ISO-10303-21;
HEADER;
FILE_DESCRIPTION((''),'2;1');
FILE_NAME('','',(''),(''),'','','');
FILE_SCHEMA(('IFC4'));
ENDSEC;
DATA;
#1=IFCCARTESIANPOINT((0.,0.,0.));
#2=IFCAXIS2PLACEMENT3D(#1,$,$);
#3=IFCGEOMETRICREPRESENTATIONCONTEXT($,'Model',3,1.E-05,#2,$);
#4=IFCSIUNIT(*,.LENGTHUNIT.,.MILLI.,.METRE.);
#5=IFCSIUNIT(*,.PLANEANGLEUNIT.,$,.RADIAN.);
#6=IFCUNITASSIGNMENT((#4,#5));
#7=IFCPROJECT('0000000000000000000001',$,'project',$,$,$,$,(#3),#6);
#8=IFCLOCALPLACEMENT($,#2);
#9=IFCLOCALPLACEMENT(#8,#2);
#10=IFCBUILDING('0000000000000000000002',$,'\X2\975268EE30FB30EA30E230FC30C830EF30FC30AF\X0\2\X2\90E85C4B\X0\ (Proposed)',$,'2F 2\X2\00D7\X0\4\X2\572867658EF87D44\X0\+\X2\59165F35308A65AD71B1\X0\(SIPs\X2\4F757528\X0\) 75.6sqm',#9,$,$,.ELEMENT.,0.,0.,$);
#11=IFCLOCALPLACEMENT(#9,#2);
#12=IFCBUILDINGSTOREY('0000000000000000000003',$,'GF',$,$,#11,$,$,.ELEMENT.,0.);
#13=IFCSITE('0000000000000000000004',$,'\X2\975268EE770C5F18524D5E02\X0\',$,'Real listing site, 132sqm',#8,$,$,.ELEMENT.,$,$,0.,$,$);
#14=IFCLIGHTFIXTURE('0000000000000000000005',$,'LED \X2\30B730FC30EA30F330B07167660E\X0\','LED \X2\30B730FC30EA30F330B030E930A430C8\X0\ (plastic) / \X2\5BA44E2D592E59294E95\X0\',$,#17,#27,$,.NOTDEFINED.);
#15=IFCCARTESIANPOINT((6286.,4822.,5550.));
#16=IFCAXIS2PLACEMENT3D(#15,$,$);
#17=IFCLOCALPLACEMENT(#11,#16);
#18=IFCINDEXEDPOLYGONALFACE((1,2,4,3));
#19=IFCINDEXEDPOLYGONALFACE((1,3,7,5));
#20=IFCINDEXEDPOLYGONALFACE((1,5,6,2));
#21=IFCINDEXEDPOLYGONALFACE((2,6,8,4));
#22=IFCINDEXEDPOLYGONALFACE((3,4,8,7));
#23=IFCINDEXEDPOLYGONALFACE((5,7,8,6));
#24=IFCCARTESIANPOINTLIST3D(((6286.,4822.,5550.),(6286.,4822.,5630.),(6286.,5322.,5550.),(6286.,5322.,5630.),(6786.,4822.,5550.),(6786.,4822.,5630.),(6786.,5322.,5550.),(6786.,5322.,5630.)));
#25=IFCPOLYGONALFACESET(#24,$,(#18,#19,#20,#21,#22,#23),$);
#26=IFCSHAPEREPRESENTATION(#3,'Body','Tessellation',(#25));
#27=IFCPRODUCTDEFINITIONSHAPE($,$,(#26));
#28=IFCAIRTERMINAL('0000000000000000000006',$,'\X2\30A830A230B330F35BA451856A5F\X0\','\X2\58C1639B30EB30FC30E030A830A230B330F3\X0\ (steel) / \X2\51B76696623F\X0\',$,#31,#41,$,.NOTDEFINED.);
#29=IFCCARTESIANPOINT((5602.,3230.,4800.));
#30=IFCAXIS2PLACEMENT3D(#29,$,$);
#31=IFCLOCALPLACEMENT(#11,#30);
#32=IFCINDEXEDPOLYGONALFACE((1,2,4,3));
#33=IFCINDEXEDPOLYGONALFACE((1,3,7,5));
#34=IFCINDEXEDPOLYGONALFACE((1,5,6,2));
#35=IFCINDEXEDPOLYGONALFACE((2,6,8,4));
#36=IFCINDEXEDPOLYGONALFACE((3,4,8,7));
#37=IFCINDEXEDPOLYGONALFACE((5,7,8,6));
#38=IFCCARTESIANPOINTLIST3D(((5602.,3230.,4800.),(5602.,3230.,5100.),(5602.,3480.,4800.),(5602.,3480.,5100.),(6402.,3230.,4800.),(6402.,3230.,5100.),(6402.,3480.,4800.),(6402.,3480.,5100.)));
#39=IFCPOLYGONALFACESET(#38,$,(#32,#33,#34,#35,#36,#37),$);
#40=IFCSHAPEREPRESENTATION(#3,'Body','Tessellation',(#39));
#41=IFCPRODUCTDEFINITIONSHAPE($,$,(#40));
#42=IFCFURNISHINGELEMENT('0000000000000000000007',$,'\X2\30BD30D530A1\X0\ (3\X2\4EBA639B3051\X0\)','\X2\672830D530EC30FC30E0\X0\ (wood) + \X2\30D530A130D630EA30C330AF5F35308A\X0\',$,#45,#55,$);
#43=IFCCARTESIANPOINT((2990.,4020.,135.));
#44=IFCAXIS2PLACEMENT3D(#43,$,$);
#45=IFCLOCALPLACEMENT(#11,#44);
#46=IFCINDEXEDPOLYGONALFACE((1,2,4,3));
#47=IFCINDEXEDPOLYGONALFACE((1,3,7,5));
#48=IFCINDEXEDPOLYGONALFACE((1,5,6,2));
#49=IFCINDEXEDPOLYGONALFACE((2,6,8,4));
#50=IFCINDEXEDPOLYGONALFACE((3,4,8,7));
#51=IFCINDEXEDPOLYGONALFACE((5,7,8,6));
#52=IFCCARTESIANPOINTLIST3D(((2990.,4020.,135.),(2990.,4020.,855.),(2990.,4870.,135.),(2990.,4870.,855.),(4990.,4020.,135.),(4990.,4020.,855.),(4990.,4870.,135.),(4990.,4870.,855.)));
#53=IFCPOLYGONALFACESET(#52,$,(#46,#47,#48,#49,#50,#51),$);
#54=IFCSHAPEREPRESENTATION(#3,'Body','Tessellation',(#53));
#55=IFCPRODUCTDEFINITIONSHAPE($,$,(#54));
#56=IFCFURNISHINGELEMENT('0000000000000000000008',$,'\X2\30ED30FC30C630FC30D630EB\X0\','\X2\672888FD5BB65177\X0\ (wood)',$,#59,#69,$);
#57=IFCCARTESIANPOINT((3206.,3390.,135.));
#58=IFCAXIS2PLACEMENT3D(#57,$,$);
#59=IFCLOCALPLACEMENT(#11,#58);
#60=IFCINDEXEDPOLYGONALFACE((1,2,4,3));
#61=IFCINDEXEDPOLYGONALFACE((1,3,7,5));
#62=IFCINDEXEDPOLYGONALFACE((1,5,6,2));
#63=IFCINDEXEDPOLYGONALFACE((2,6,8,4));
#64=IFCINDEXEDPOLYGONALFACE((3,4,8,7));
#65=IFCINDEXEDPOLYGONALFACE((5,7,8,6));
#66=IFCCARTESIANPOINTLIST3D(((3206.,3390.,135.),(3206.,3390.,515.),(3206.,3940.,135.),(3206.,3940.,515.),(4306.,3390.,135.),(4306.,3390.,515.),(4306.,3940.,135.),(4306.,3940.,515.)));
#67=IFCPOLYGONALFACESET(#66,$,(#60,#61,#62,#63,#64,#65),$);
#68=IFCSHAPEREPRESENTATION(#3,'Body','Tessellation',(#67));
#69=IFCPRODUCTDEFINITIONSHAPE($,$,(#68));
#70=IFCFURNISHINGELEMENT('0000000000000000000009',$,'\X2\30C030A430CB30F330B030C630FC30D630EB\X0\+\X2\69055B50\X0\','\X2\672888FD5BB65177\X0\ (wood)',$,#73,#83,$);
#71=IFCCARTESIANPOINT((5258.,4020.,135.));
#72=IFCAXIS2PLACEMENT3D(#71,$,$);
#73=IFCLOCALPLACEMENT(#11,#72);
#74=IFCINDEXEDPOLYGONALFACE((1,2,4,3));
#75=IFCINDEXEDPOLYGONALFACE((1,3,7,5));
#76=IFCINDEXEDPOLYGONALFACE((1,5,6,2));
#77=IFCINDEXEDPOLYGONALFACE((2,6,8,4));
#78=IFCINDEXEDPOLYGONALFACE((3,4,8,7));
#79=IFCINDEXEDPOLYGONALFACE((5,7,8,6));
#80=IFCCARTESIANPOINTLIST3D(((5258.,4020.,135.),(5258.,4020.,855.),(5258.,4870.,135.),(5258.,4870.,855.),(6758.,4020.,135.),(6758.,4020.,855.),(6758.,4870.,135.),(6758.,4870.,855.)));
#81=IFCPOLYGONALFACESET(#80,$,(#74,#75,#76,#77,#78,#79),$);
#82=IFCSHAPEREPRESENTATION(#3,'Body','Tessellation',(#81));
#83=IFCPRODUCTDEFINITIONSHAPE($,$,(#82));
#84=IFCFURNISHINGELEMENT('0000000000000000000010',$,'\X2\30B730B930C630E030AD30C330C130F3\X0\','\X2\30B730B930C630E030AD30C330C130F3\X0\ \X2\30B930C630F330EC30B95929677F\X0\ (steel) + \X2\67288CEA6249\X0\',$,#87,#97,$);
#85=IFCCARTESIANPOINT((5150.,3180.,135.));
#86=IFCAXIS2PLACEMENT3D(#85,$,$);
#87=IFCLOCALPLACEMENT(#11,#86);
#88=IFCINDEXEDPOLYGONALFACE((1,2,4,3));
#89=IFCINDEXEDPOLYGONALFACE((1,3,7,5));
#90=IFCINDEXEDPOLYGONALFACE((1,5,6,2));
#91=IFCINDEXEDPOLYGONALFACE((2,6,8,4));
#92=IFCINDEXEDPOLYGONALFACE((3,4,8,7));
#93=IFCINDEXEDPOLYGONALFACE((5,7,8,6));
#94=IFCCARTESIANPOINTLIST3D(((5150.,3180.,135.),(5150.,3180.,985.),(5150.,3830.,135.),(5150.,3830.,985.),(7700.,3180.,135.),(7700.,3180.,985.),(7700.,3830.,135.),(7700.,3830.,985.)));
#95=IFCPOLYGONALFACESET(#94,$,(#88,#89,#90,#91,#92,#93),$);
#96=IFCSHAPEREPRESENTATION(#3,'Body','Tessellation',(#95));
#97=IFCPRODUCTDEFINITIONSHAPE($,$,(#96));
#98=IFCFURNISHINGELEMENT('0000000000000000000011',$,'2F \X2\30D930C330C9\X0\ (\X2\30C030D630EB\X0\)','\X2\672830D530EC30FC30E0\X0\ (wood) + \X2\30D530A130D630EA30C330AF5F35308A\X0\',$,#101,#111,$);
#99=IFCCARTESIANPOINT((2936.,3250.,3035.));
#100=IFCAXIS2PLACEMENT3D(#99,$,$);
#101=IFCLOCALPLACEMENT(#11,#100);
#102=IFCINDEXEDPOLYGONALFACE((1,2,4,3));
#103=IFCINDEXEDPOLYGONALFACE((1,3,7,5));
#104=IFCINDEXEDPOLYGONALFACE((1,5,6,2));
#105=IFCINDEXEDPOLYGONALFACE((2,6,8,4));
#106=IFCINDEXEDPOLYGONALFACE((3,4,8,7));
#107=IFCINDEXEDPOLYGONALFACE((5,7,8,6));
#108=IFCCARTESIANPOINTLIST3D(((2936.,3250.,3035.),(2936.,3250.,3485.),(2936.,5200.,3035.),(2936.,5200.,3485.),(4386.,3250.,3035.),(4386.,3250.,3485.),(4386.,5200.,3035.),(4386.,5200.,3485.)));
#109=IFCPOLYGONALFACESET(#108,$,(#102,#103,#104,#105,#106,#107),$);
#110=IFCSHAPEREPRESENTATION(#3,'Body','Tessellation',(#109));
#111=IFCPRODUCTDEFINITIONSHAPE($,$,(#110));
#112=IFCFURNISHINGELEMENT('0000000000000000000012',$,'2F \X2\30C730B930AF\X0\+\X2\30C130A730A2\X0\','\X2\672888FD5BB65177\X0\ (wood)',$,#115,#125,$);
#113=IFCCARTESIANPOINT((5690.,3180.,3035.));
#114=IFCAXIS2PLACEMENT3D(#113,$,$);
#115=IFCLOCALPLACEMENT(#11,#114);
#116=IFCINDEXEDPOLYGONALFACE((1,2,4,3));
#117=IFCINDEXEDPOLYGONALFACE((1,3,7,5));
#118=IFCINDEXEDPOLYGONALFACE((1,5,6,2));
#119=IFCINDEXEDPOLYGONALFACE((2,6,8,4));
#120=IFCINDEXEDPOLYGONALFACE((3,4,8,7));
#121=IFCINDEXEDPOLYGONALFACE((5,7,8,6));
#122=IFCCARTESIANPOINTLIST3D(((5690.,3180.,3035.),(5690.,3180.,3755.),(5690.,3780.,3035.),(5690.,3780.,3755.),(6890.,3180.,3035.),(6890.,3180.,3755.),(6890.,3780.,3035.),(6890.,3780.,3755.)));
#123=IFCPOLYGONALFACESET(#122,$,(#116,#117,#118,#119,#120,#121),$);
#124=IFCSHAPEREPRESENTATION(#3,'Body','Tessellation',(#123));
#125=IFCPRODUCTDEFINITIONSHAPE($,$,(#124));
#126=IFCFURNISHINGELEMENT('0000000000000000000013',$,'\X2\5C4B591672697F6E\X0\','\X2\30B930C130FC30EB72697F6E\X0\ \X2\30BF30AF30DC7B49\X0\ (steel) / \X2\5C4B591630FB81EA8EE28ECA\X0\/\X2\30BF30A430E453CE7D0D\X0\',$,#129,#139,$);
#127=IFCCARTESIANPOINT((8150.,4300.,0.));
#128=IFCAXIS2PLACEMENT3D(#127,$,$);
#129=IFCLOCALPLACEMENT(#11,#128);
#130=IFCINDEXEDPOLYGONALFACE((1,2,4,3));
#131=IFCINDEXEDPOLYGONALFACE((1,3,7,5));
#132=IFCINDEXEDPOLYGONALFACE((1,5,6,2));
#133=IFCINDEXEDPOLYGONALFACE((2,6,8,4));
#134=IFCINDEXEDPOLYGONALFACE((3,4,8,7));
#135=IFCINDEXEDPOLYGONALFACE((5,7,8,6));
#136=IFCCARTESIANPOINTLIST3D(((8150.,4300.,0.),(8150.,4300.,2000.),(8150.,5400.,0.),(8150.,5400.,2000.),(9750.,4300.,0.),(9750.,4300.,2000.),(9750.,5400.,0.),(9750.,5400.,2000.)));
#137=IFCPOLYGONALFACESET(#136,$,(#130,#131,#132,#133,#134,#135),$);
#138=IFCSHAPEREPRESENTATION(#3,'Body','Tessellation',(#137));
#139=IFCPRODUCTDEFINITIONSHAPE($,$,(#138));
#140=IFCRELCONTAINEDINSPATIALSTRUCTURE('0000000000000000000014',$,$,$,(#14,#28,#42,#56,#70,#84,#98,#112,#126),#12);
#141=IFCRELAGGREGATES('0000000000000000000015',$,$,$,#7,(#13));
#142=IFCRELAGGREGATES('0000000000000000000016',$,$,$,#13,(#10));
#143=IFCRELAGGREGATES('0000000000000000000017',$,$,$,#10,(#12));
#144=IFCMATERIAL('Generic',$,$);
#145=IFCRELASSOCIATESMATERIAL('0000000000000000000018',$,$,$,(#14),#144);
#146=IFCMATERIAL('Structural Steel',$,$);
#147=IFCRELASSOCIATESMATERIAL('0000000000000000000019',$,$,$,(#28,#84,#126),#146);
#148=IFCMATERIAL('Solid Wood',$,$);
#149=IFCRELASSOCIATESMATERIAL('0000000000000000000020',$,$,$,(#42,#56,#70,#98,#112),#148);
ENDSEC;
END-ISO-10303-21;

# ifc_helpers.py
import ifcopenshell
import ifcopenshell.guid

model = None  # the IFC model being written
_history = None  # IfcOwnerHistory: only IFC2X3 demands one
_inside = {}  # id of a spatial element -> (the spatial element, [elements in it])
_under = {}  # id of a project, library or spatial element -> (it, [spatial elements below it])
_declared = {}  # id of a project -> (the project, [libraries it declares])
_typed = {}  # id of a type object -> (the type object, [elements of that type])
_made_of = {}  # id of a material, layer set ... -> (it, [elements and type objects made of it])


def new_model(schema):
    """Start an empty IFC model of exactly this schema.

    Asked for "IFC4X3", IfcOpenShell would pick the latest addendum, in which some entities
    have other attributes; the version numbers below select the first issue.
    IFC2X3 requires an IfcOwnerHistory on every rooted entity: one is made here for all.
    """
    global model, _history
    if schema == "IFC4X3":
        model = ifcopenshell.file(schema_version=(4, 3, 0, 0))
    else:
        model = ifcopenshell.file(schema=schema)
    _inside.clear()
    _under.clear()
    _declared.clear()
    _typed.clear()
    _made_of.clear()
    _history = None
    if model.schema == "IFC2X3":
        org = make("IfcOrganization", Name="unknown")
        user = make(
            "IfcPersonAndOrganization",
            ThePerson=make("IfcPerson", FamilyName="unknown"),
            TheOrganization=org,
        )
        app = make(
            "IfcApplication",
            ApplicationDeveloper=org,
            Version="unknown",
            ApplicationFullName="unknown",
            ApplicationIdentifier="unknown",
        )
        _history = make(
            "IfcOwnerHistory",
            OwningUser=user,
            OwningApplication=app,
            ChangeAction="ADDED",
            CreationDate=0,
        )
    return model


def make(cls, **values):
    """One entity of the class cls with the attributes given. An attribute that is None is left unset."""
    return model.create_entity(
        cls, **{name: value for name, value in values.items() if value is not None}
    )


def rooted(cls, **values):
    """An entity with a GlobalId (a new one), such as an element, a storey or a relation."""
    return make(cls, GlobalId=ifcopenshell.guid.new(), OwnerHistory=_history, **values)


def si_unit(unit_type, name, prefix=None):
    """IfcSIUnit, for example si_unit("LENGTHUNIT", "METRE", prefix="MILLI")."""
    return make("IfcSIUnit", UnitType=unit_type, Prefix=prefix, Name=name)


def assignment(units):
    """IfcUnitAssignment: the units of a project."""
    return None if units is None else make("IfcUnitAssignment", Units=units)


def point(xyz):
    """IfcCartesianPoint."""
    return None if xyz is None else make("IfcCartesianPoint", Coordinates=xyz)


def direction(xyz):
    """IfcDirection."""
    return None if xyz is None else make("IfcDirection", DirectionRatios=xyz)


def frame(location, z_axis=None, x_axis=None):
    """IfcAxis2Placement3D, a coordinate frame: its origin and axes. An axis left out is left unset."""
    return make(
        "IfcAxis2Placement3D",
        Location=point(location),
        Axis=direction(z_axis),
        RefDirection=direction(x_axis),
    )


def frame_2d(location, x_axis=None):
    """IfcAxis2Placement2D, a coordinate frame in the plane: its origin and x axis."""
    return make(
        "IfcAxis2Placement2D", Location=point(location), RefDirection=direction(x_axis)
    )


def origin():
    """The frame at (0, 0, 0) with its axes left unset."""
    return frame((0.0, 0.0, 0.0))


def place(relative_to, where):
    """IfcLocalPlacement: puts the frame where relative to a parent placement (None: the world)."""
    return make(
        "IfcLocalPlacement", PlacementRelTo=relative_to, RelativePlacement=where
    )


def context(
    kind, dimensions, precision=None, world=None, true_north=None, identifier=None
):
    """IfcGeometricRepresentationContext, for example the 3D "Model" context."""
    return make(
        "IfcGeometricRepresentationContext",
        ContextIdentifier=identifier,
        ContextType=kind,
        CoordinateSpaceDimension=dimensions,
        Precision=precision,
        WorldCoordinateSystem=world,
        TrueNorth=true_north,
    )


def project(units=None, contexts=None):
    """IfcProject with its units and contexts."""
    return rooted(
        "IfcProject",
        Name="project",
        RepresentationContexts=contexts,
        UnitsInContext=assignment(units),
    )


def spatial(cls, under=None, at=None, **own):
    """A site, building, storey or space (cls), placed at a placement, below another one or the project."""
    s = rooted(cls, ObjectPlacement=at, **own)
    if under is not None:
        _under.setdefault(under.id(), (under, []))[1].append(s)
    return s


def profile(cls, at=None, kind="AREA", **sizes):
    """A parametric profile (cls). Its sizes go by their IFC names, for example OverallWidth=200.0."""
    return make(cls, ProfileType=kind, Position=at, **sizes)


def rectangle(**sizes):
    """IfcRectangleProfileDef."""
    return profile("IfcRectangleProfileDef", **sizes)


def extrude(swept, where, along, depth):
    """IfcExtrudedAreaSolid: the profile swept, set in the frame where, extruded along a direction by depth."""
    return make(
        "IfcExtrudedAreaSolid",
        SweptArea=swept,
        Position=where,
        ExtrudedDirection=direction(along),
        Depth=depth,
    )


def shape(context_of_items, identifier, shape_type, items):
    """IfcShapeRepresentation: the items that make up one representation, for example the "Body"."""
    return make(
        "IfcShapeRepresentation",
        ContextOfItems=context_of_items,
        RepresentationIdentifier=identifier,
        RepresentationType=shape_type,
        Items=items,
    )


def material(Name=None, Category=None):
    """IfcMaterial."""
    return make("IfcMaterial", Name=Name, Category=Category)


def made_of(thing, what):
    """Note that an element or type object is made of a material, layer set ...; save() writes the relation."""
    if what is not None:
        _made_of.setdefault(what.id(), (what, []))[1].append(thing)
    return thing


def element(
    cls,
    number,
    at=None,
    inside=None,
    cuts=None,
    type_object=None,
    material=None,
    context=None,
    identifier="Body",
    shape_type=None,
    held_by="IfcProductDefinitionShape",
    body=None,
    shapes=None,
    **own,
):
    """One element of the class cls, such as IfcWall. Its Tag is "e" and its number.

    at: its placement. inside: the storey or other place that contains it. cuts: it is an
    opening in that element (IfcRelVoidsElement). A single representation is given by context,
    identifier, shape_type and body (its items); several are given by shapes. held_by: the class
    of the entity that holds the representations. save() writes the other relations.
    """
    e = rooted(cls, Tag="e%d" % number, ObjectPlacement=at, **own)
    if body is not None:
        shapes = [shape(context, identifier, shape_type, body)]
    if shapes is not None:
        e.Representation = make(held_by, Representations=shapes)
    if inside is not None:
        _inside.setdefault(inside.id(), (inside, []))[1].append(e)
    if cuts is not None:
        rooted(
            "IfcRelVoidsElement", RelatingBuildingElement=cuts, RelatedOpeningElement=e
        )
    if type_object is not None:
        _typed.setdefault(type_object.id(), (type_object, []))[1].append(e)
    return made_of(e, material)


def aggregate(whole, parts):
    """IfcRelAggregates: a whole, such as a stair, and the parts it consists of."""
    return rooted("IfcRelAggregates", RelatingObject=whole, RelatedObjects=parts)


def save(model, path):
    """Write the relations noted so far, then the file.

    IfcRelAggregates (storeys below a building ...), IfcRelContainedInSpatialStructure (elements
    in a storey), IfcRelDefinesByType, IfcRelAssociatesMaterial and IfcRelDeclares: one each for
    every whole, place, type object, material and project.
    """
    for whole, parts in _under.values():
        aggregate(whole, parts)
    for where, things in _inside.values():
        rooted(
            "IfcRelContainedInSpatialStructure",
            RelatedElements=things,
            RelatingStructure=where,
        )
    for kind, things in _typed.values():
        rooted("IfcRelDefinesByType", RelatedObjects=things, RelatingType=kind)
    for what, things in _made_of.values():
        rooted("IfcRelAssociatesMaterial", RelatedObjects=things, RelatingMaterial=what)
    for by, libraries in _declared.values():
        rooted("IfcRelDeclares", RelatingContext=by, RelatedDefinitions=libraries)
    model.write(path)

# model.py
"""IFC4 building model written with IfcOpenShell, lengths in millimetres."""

from ifc_helpers import new_model, si_unit, frame, frame_2d, origin, place, context, project, spatial, rectangle, extrude, material, element, save


model = new_model("IFC4")

# Units and contexts
model_context = context("Model", 3, precision=1e-05, world=origin())
ifc_project = project(units=[si_unit("LENGTHUNIT", "METRE", prefix="MILLI"), si_unit("PLANEANGLEUNIT", "RADIAN")], contexts=[model_context])

# Site, building, storey
site_placement = place(None, origin())
site = spatial("IfcSite", under=ifc_project, at=site_placement, Name="青森県弘前市", ObjectType="Real listing site, 132sqm", CompositionType="ELEMENT", RefElevation=0.0)
building_placement = place(site_placement, origin())
building = spatial("IfcBuilding", under=site, at=building_placement, Name="青森・リモートワーク2部屋 (Proposed)", ObjectType="2F 2×4在来軸組+外張り断熱(SIPs併用) 75.6sqm", CompositionType="ELEMENT", ElevationOfRefHeight=0.0, ElevationOfTerrain=0.0)
storey_placement = place(building_placement, origin())
storey = spatial("IfcBuildingStorey", under=building, at=storey_placement, Name="GF", CompositionType="ELEMENT", Elevation=0.0)

# Shared definitions
ifc_material_1 = material(Name="Solid Wood")

# Shared definitions
ifc_material_2 = material(Name="Generic")

# Shared definitions
ifc_material_3 = material(Name="Structural Steel")

# Light fixture
light_fixture_placement = place(storey_placement, frame((6286.0, 4822.0, 5550.0)))
element("IfcLightFixture", 1, at=light_fixture_placement, inside=storey, material=ifc_material_2, Name="LED シーリング照明", Description="LED シーリングライト (plastic) / 室中央天井", PredefinedType="NOTDEFINED", context=model_context, shape_type="SweptSolid", body=[
    extrude(rectangle(XDim=500.0, YDim=500.0, at=frame_2d((250.0, 250.0))), frame((6286.0, 4822.0, 5550.0)), (0.0, 0.0, 1.0), 80.0),
])

# Air terminal
air_terminal_1_placement = place(storey_placement, frame((5602.0, 3230.0, 4800.0)))
element("IfcAirTerminal", 2, at=air_terminal_1_placement, inside=storey, material=ifc_material_3, Name="エアコン室内機", Description="壁掛ルームエアコン (steel) / 冷暖房", PredefinedType="NOTDEFINED", context=model_context, shape_type="SweptSolid", body=[
    extrude(rectangle(XDim=800.0, YDim=250.0, at=frame_2d((400.0, 125.0))), frame((5602.0, 3230.0, 4800.0)), (0.0, 0.0, 1.0), 300.0),
])

# Furnishing elements
furnishing_1_placement = place(storey_placement, frame((2990.0, 4020.0, 135.0)))
element("IfcFurnishingElement", 3, at=furnishing_1_placement, inside=storey, material=ifc_material_1, Name="ソファ (3人掛け)", Description="木フレーム (wood) + ファブリック張り", context=model_context, shape_type="SweptSolid", body=[
    extrude(rectangle(XDim=2000.0, YDim=850.0, at=frame_2d((1000.0, 425.0))), frame((2990.0, 4020.0, 135.0)), (0.0, 0.0, 1.0), 720.0),
])
furnishing_2_placement = place(storey_placement, frame((3206.0, 3390.0, 135.0)))
element("IfcFurnishingElement", 4, at=furnishing_2_placement, inside=storey, material=ifc_material_1, Name="ローテーブル", Description="木製家具 (wood)", context=model_context, shape_type="SweptSolid", body=[
    extrude(rectangle(XDim=1100.0, YDim=550.0, at=frame_2d((550.0, 275.0))), frame((3206.0, 3390.0, 135.0)), (0.0, 0.0, 1.0), 380.0),
])
furnishing_3_placement = place(storey_placement, frame((5258.0, 4020.0, 135.0)))
element("IfcFurnishingElement", 5, at=furnishing_3_placement, inside=storey, material=ifc_material_1, Name="ダイニングテーブル+椅子", Description="木製家具 (wood)", context=model_context, shape_type="SweptSolid", body=[
    extrude(rectangle(XDim=1500.0, YDim=850.0, at=frame_2d((750.0, 425.0))), frame((5258.0, 4020.0, 135.0)), (0.0, 0.0, 1.0), 720.0),
])
furnishing_4_placement = place(storey_placement, frame((5150.0, 3180.0, 135.0)))
element("IfcFurnishingElement", 6, at=furnishing_4_placement, inside=storey, material=ifc_material_3, Name="システムキッチン", Description="システムキッチン ステンレス天板 (steel) + 木質扉", context=model_context, shape_type="SweptSolid", body=[
    extrude(rectangle(XDim=2550.0, YDim=650.0, at=frame_2d((1275.0, 325.0))), frame((5150.0, 3180.0, 135.0)), (0.0, 0.0, 1.0), 850.0),
])
furnishing_5_placement = place(storey_placement, frame((2936.0, 3250.0, 3035.0)))
element("IfcFurnishingElement", 7, at=furnishing_5_placement, inside=storey, material=ifc_material_1, Name="2F ベッド (ダブル)", Description="木フレーム (wood) + ファブリック張り", context=model_context, shape_type="SweptSolid", body=[
    extrude(rectangle(XDim=1450.0, YDim=1950.0, at=frame_2d((725.0, 975.0))), frame((2936.0, 3250.0, 3035.0)), (0.0, 0.0, 1.0), 450.0),
])
furnishing_6_placement = place(storey_placement, frame((5690.0, 3180.0, 3035.0)))
element("IfcFurnishingElement", 8, at=furnishing_6_placement, inside=storey, material=ifc_material_1, Name="2F デスク+チェア", Description="木製家具 (wood)", context=model_context, shape_type="SweptSolid", body=[
    extrude(rectangle(XDim=1200.0, YDim=600.0, at=frame_2d((600.0, 300.0))), frame((5690.0, 3180.0, 3035.0)), (0.0, 0.0, 1.0), 720.0),
])
furnishing_7_placement = place(storey_placement, frame((8150.0, 4300.0, 0.0)))
element("IfcFurnishingElement", 9, at=furnishing_7_placement, inside=storey, material=ifc_material_3, Name="屋外物置", Description="スチール物置 タクボ等 (steel) / 屋外・自転車/タイヤ収納", context=model_context, shape_type="SweptSolid", body=[
    extrude(rectangle(XDim=1600.0, YDim=1100.0, at=frame_2d((800.0, 550.0))), frame((8150.0, 4300.0, 0.0)), (0.0, 0.0, 1.0), 2000.0),
])

save(model, "model.ifc")
